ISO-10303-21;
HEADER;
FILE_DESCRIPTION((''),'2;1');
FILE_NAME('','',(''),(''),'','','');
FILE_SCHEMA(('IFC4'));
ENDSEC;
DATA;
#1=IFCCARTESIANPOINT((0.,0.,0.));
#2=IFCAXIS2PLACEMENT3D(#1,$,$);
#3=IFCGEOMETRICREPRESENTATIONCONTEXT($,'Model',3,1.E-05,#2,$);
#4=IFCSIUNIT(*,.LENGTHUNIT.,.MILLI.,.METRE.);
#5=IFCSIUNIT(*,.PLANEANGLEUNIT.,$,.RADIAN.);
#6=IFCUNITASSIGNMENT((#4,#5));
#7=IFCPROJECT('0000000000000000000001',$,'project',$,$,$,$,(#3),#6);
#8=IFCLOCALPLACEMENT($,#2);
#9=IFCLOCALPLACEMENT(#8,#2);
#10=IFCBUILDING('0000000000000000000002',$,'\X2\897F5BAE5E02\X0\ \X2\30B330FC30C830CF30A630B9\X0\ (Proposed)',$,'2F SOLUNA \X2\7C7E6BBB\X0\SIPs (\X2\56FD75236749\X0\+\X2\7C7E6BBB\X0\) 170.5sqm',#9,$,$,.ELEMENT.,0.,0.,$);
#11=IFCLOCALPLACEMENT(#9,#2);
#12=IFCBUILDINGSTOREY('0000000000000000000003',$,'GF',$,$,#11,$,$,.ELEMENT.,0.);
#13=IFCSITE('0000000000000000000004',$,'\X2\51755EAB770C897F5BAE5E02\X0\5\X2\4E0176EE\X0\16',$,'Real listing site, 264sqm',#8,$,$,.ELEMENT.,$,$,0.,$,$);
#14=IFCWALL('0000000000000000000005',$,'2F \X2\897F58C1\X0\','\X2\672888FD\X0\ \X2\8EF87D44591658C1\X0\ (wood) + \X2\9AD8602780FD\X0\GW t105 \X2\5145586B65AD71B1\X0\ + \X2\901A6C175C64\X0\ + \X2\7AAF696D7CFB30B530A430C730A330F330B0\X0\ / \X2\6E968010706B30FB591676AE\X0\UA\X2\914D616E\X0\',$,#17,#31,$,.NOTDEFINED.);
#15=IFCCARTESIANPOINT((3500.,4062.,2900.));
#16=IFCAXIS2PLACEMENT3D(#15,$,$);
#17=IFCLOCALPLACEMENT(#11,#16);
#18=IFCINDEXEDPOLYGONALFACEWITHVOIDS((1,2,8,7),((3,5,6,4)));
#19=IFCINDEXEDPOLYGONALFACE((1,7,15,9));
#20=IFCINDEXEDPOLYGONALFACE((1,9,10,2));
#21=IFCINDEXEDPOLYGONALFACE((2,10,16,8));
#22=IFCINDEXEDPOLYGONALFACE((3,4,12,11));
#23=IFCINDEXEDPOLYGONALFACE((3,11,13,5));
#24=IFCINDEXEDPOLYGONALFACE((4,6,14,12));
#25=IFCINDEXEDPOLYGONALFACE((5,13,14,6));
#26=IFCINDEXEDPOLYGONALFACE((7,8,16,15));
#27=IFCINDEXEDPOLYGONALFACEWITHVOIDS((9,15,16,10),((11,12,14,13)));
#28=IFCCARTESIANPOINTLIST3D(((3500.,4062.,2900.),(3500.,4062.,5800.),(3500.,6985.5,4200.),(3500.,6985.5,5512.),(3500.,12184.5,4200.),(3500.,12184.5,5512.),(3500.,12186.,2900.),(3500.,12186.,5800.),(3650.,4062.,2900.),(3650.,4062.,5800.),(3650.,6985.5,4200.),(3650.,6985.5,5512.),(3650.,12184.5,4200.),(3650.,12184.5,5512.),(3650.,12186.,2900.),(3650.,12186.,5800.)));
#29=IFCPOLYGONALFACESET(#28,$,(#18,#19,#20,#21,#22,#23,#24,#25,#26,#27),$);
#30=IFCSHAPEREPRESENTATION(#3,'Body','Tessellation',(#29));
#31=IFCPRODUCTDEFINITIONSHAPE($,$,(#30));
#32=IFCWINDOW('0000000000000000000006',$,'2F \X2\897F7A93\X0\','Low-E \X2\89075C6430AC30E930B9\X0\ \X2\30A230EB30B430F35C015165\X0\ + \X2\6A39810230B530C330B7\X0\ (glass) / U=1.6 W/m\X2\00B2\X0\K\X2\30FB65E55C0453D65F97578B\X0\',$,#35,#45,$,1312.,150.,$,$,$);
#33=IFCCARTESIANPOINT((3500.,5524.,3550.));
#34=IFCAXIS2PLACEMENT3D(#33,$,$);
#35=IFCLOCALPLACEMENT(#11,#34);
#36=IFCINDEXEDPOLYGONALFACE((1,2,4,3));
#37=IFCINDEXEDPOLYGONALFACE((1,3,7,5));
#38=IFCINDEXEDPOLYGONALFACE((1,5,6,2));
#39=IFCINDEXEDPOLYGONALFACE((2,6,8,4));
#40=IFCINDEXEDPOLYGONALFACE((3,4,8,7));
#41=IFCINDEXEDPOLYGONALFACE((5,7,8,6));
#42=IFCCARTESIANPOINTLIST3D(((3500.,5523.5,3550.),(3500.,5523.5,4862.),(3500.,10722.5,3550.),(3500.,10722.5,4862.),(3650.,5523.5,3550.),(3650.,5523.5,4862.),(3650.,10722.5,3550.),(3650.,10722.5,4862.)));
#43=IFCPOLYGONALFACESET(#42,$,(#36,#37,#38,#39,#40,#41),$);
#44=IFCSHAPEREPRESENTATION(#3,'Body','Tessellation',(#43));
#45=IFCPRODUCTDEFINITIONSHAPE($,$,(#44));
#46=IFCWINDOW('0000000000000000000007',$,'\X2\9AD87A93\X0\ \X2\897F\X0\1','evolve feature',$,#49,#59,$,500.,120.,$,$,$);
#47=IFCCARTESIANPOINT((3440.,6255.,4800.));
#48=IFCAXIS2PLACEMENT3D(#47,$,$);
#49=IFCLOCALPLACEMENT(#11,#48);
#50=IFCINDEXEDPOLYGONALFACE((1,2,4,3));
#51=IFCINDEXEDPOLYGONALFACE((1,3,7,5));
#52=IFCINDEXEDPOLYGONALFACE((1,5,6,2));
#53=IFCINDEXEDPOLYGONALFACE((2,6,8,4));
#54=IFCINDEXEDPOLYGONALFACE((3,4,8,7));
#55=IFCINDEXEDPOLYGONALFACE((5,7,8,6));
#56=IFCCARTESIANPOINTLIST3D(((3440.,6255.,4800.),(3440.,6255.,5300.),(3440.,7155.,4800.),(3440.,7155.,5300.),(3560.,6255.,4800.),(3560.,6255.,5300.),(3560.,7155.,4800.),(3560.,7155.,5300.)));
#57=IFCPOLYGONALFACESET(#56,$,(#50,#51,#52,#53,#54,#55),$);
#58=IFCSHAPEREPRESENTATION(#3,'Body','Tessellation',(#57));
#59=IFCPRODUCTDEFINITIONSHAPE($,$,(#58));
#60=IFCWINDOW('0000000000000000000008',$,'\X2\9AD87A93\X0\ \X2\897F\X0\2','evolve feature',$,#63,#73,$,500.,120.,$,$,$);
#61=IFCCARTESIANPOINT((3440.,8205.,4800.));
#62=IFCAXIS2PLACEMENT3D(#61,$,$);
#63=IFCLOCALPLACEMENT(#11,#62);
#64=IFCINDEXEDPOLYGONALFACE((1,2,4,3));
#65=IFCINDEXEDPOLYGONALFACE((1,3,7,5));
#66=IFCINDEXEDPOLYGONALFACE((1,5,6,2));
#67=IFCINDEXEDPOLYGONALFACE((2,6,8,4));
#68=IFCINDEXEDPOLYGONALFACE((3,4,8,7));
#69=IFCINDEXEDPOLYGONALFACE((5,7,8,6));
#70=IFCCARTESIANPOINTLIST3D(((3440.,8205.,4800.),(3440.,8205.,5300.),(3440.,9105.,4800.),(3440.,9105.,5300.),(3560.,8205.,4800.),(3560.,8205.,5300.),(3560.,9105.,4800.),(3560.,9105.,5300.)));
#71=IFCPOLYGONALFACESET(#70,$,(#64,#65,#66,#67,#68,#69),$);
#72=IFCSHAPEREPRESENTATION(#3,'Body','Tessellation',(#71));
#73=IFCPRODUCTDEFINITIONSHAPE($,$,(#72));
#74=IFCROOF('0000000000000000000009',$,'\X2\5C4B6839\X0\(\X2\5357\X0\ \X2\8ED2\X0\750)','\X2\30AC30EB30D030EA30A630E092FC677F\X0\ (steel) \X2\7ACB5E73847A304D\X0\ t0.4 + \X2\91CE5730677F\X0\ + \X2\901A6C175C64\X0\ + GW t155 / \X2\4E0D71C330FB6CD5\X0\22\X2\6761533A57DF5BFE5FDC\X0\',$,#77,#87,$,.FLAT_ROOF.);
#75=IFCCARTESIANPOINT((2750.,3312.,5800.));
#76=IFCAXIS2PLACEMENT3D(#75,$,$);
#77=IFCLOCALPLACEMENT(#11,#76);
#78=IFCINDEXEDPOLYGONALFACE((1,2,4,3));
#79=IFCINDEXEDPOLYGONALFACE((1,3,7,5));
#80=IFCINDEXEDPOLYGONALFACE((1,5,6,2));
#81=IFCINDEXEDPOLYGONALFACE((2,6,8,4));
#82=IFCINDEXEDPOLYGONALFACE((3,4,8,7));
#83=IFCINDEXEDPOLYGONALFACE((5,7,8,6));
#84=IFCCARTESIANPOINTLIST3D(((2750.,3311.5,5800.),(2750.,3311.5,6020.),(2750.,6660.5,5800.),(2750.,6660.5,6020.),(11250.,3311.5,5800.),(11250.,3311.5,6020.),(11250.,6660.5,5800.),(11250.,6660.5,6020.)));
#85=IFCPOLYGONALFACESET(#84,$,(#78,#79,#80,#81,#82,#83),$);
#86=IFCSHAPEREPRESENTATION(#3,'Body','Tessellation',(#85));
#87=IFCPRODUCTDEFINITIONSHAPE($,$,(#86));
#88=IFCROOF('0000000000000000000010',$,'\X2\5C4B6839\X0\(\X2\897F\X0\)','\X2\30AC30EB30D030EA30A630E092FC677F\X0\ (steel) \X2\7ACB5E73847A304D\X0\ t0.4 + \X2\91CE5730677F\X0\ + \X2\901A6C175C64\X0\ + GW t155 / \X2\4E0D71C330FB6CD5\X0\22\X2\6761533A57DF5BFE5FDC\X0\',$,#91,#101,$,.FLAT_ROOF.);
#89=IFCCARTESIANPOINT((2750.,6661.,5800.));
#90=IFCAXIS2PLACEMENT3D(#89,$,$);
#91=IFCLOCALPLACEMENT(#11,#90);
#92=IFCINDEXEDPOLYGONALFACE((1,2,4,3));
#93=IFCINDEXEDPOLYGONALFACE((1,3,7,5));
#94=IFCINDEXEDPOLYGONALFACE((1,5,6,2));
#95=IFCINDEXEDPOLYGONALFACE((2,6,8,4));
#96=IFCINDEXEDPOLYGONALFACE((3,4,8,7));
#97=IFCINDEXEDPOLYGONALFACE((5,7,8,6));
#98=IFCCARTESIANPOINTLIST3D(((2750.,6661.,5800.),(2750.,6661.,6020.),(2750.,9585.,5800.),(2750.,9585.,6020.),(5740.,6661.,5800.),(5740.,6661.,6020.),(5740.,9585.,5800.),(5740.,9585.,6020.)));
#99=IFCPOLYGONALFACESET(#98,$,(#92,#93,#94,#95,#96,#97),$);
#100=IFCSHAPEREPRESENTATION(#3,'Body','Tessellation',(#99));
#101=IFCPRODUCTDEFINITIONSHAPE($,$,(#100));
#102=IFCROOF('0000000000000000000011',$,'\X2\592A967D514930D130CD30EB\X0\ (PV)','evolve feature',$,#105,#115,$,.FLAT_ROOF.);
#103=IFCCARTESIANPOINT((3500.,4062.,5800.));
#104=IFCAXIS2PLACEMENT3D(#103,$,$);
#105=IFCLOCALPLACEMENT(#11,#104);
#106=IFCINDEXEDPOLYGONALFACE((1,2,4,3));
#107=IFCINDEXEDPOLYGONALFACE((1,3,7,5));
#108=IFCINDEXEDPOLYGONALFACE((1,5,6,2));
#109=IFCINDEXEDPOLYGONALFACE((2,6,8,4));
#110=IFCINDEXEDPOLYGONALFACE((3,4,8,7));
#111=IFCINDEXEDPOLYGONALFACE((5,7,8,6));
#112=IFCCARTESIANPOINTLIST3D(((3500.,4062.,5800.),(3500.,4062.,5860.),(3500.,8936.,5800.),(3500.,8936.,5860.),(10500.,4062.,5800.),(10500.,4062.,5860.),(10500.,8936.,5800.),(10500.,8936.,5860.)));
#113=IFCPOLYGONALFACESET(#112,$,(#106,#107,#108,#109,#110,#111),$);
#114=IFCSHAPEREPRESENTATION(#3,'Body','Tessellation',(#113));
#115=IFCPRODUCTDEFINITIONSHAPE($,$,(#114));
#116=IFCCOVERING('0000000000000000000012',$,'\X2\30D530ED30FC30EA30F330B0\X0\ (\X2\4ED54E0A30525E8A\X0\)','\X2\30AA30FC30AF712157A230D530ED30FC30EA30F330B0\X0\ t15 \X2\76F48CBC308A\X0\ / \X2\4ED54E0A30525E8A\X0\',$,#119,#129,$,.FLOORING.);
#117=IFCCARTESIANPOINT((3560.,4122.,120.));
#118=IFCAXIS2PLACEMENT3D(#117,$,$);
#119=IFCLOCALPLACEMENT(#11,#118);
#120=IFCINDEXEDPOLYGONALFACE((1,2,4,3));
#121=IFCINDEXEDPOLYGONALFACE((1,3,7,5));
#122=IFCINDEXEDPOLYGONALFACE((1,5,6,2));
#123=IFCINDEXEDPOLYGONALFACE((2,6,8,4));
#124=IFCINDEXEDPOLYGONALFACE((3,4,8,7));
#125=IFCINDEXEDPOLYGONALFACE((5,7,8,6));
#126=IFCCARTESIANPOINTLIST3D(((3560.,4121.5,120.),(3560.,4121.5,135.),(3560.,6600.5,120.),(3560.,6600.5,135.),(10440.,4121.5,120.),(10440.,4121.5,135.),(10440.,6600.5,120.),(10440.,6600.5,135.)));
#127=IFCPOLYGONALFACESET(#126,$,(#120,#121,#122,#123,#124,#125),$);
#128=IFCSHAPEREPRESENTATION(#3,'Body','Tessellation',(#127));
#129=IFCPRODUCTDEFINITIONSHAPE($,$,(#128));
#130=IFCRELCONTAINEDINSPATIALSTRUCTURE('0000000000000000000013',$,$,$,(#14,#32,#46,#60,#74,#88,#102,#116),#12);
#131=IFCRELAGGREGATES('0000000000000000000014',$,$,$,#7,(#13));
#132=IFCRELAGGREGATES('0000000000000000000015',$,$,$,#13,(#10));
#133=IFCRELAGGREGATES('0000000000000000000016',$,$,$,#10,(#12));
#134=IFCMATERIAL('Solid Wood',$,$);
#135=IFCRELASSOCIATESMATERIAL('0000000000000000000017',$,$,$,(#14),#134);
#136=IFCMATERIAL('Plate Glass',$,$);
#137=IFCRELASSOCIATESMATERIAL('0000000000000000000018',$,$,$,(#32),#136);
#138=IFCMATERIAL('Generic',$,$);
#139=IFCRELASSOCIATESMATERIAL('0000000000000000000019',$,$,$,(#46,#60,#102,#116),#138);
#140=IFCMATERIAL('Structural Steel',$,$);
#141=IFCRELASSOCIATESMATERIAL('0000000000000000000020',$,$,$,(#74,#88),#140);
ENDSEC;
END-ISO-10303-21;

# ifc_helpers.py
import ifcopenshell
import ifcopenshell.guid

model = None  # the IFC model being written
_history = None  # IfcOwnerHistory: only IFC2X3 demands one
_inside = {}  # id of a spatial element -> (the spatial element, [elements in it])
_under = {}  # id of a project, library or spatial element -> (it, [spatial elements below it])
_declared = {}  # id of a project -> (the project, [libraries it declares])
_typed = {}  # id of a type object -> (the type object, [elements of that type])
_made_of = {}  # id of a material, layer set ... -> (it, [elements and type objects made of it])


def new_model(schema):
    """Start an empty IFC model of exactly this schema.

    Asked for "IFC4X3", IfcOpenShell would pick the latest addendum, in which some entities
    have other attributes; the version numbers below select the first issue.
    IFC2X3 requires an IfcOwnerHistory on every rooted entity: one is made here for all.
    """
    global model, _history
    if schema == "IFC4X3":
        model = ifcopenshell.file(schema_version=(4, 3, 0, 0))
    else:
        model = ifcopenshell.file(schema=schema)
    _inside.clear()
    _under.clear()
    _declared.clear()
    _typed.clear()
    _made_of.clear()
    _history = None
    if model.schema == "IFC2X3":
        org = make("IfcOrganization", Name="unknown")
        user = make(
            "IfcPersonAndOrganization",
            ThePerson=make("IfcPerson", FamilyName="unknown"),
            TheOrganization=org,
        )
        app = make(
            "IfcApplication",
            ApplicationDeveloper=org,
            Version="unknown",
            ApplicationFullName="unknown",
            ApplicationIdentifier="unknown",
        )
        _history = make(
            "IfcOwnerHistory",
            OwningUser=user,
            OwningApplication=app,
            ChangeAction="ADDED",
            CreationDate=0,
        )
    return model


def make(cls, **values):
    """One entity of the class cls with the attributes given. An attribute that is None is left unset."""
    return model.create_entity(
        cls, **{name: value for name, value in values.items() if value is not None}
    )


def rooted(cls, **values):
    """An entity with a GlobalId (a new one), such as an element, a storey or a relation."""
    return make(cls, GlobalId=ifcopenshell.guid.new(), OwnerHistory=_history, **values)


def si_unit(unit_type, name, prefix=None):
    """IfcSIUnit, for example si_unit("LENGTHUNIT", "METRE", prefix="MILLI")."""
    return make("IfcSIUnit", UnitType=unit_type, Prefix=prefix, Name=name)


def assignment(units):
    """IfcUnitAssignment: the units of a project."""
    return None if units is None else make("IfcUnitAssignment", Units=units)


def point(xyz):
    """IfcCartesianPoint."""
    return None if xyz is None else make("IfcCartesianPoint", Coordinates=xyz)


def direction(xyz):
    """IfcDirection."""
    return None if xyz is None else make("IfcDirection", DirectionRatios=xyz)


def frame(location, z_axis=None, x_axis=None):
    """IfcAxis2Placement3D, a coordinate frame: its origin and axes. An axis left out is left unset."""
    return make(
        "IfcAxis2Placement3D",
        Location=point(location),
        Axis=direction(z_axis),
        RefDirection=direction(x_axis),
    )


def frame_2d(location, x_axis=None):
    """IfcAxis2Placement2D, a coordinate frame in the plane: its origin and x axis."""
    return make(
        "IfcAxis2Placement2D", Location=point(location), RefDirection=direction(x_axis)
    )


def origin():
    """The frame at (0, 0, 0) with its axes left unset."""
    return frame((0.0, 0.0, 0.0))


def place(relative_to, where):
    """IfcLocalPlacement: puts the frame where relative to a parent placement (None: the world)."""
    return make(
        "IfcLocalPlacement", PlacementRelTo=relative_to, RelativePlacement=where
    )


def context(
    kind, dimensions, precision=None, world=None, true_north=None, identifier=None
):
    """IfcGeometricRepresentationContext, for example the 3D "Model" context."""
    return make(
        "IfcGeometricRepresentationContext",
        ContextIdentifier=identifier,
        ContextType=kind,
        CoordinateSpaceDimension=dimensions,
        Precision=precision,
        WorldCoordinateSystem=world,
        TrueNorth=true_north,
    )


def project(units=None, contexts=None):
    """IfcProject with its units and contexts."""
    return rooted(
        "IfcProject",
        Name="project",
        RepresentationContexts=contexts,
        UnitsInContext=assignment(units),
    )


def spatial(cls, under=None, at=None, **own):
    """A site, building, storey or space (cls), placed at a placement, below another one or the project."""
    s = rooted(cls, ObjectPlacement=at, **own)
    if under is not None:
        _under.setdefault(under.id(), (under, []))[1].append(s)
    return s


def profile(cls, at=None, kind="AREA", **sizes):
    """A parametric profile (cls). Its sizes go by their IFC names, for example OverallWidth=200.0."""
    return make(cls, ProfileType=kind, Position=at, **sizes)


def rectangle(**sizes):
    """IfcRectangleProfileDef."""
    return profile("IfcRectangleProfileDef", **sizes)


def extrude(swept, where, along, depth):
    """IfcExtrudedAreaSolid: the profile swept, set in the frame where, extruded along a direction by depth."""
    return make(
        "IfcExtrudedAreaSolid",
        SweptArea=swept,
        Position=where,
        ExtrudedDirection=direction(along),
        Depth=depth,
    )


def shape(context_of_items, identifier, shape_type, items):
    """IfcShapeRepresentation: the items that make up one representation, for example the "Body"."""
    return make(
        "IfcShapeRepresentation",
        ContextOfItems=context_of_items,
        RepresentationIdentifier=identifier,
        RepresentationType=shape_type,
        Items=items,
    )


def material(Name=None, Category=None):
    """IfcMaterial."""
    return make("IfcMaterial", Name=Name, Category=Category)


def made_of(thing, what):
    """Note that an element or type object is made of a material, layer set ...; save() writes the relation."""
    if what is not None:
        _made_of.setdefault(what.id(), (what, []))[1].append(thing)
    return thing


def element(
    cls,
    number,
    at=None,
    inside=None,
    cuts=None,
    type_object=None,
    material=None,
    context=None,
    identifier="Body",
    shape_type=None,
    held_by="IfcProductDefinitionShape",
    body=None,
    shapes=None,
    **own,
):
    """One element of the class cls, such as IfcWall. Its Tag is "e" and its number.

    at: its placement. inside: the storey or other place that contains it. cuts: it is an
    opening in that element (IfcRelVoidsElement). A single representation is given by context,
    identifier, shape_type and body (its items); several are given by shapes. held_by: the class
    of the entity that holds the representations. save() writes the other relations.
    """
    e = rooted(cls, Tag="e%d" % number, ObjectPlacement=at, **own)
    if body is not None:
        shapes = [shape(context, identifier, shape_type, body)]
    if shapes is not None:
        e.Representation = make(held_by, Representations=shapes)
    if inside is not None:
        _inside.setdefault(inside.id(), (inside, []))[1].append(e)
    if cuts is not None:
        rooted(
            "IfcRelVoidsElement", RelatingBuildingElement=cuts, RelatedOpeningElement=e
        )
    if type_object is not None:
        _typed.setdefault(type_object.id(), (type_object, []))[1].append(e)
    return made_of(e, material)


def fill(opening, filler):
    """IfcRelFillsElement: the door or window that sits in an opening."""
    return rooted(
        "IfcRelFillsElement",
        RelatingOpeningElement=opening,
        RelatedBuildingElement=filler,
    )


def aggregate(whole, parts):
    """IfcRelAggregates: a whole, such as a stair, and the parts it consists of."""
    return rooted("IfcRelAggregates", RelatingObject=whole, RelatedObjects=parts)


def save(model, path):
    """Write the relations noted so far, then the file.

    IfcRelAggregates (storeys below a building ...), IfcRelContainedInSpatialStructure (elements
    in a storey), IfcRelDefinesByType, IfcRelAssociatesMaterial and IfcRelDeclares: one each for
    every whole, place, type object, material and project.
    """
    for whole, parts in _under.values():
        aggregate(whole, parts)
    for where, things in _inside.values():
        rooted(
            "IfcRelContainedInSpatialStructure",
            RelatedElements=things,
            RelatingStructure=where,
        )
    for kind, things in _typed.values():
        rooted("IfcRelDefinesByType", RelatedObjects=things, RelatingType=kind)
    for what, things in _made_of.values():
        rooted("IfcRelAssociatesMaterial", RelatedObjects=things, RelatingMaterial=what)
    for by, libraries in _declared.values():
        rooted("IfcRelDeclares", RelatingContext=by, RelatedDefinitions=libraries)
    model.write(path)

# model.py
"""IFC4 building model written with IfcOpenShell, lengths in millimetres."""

from ifc_helpers import new_model, si_unit, frame, frame_2d, origin, place, context, project, spatial, rectangle, extrude, material, element, fill, save


model = new_model("IFC4")

# Units and contexts
model_context = context("Model", 3, precision=1e-05, world=origin())
ifc_project = project(units=[si_unit("LENGTHUNIT", "METRE", prefix="MILLI"), si_unit("PLANEANGLEUNIT", "RADIAN")], contexts=[model_context])

# Site, building, storey
site_placement = place(None, origin())
site = spatial("IfcSite", under=ifc_project, at=site_placement, Name="兵庫県西宮市5丁目16", ObjectType="Real listing site, 264sqm", CompositionType="ELEMENT", RefElevation=0.0)
building_placement = place(site_placement, origin())
building = spatial("IfcBuilding", under=site, at=building_placement, Name="西宮市 コートハウス (Proposed)", ObjectType="2F SOLUNA 籾殻SIPs (国産杉+籾殻) 170.5sqm", CompositionType="ELEMENT", ElevationOfRefHeight=0.0, ElevationOfTerrain=0.0)
storey_placement = place(building_placement, origin())
storey = spatial("IfcBuildingStorey", under=building, at=storey_placement, Name="GF", CompositionType="ELEMENT", Elevation=0.0)

# Shared definitions
ifc_material_1 = material(Name="Solid Wood")
ifc_material_2 = material(Name="Generic")

# Shared definitions
ifc_material_3 = material(Name="Plate Glass")

# Wall, openings, windows
wall_1_placement = place(storey_placement, frame((3500.0, 4062.0, 2900.0)))
wall_1 = element("IfcWall", 1, at=wall_1_placement, inside=storey, material=ifc_material_1, Name="2F 西壁", Description="木製 軸組外壁 (wood) + 高性能GW t105 充填断熱 + 通気層 + 窯業系サイディング / 準耐火・外皮UA配慮", PredefinedType="NOTDEFINED", context=model_context, shape_type="SweptSolid", body=[
    extrude(rectangle(XDim=150.0, YDim=8124.0, at=frame_2d((75.0, 4062.0))), frame((3500.0, 4062.0, 2900.0)), (0.0, 0.0, 1.0), 2900.0),
])
opening_1_placement = place(storey_placement, frame((3500.0, 5524.0, 3550.0)))
opening_1 = element("IfcOpeningElement", 2, at=opening_1_placement, cuts=wall_1, PredefinedType="NOTDEFINED", context=model_context, shape_type="SweptSolid", body=[
    extrude(rectangle(XDim=150.0, YDim=5199.0, at=frame_2d((75.0, 2599.0))), frame((3500.0, 5524.0, 3550.0)), (0.0, 0.0, 1.0), 1312.0),
])
opening_2_placement = place(storey_placement, frame((3440.0, 6255.0, 4800.0)))
opening_2 = element("IfcOpeningElement", 3, at=opening_2_placement, cuts=wall_1, PredefinedType="NOTDEFINED", context=model_context, shape_type="SweptSolid", body=[
    extrude(rectangle(XDim=120.0, YDim=900.0, at=frame_2d((60.0, 450.0))), frame((3440.0, 6255.0, 4800.0)), (0.0, 0.0, 1.0), 500.0),
])
opening_3_placement = place(storey_placement, frame((3440.0, 8205.0, 4800.0)))
opening_3 = element("IfcOpeningElement", 4, at=opening_3_placement, cuts=wall_1, PredefinedType="NOTDEFINED", context=model_context, shape_type="SweptSolid", body=[
    extrude(rectangle(XDim=120.0, YDim=900.0, at=frame_2d((60.0, 450.0))), frame((3440.0, 8205.0, 4800.0)), (0.0, 0.0, 1.0), 500.0),
])
window_1_placement = place(storey_placement, frame((3500.0, 5524.0, 3550.0)))
window_1 = element("IfcWindow", 5, at=window_1_placement, inside=storey, material=ifc_material_3, Name="2F 西窓", Description="Low-E 複層ガラス アルゴン封入 + 樹脂サッシ (glass) / U=1.6 W/m²K・日射取得型", OverallHeight=1312.0, OverallWidth=150.0, context=model_context, shape_type="SweptSolid", body=[
    extrude(rectangle(XDim=150.0, YDim=5199.0, at=frame_2d((75.0, 2599.0))), frame((3500.0, 5524.0, 3550.0)), (0.0, 0.0, 1.0), 1312.0),
])
fill(opening_1, window_1)
window_2_placement = place(storey_placement, frame((3440.0, 6255.0, 4800.0)))
window_2 = element("IfcWindow", 6, at=window_2_placement, inside=storey, material=ifc_material_2, Name="高窓 西1", Description="evolve feature", OverallHeight=500.0, OverallWidth=120.0, context=model_context, shape_type="SweptSolid", body=[
    extrude(rectangle(XDim=120.0, YDim=900.0, at=frame_2d((60.0, 450.0))), frame((3440.0, 6255.0, 4800.0)), (0.0, 0.0, 1.0), 500.0),
])
fill(opening_2, window_2)
window_3_placement = place(storey_placement, frame((3440.0, 8205.0, 4800.0)))
window_3 = element("IfcWindow", 7, at=window_3_placement, inside=storey, material=ifc_material_2, Name="高窓 西2", Description="evolve feature", OverallHeight=500.0, OverallWidth=120.0, context=model_context, shape_type="SweptSolid", body=[
    extrude(rectangle(XDim=120.0, YDim=900.0, at=frame_2d((60.0, 450.0))), frame((3440.0, 8205.0, 4800.0)), (0.0, 0.0, 1.0), 500.0),
])
fill(opening_3, window_3)

# Roofs
ifc_material_4 = material(Name="Structural Steel")
roof_1_placement = place(storey_placement, frame((2750.0, 3312.0, 5800.0)))
element("IfcRoof", 8, at=roof_1_placement, inside=storey, material=ifc_material_4, Name="屋根(南 軒750)", Description="ガルバリウム鋼板 (steel) 立平葺き t0.4 + 野地板 + 通気層 + GW t155 / 不燃・法22条区域対応", PredefinedType="FLAT_ROOF", context=model_context, shape_type="SweptSolid", body=[
    extrude(rectangle(XDim=8500.0, YDim=3349.0, at=frame_2d((4250.0, 1674.0))), frame((2750.0, 3312.0, 5800.0)), (0.0, 0.0, 1.0), 220.0),
])
roof_2_placement = place(storey_placement, frame((2750.0, 6661.0, 5800.0)))
element("IfcRoof", 9, at=roof_2_placement, inside=storey, material=ifc_material_4, Name="屋根(西)", Description="ガルバリウム鋼板 (steel) 立平葺き t0.4 + 野地板 + 通気層 + GW t155 / 不燃・法22条区域対応", PredefinedType="FLAT_ROOF", context=model_context, shape_type="SweptSolid", body=[
    extrude(rectangle(XDim=2990.0, YDim=2924.0, at=frame_2d((1495.0, 1462.0))), frame((2750.0, 6661.0, 5800.0)), (0.0, 0.0, 1.0), 220.0),
])
roof_3_placement = place(storey_placement, frame((3500.0, 4062.0, 5800.0)))
element("IfcRoof", 10, at=roof_3_placement, inside=storey, material=ifc_material_2, Name="太陽光パネル (PV)", Description="evolve feature", PredefinedType="FLAT_ROOF", context=model_context, shape_type="SweptSolid", body=[
    extrude(rectangle(XDim=7000.0, YDim=4874.0, at=frame_2d((3500.0, 2437.0))), frame((3500.0, 4062.0, 5800.0)), (0.0, 0.0, 1.0), 60.0),
])

# Covering
covering_placement = place(storey_placement, frame((3560.0, 4122.0, 120.0)))
element("IfcCovering", 11, at=covering_placement, inside=storey, material=ifc_material_2, Name="フローリング (仕上げ床)", Description="オーク無垢フローリング t15 直貼り / 仕上げ床", PredefinedType="FLOORING", context=model_context, shape_type="SweptSolid", body=[
    extrude(rectangle(XDim=6880.0, YDim=2479.0, at=frame_2d((3440.0, 1239.0))), frame((3560.0, 4122.0, 120.0)), (0.0, 0.0, 1.0), 15.0),
])

save(model, "model.ifc")
